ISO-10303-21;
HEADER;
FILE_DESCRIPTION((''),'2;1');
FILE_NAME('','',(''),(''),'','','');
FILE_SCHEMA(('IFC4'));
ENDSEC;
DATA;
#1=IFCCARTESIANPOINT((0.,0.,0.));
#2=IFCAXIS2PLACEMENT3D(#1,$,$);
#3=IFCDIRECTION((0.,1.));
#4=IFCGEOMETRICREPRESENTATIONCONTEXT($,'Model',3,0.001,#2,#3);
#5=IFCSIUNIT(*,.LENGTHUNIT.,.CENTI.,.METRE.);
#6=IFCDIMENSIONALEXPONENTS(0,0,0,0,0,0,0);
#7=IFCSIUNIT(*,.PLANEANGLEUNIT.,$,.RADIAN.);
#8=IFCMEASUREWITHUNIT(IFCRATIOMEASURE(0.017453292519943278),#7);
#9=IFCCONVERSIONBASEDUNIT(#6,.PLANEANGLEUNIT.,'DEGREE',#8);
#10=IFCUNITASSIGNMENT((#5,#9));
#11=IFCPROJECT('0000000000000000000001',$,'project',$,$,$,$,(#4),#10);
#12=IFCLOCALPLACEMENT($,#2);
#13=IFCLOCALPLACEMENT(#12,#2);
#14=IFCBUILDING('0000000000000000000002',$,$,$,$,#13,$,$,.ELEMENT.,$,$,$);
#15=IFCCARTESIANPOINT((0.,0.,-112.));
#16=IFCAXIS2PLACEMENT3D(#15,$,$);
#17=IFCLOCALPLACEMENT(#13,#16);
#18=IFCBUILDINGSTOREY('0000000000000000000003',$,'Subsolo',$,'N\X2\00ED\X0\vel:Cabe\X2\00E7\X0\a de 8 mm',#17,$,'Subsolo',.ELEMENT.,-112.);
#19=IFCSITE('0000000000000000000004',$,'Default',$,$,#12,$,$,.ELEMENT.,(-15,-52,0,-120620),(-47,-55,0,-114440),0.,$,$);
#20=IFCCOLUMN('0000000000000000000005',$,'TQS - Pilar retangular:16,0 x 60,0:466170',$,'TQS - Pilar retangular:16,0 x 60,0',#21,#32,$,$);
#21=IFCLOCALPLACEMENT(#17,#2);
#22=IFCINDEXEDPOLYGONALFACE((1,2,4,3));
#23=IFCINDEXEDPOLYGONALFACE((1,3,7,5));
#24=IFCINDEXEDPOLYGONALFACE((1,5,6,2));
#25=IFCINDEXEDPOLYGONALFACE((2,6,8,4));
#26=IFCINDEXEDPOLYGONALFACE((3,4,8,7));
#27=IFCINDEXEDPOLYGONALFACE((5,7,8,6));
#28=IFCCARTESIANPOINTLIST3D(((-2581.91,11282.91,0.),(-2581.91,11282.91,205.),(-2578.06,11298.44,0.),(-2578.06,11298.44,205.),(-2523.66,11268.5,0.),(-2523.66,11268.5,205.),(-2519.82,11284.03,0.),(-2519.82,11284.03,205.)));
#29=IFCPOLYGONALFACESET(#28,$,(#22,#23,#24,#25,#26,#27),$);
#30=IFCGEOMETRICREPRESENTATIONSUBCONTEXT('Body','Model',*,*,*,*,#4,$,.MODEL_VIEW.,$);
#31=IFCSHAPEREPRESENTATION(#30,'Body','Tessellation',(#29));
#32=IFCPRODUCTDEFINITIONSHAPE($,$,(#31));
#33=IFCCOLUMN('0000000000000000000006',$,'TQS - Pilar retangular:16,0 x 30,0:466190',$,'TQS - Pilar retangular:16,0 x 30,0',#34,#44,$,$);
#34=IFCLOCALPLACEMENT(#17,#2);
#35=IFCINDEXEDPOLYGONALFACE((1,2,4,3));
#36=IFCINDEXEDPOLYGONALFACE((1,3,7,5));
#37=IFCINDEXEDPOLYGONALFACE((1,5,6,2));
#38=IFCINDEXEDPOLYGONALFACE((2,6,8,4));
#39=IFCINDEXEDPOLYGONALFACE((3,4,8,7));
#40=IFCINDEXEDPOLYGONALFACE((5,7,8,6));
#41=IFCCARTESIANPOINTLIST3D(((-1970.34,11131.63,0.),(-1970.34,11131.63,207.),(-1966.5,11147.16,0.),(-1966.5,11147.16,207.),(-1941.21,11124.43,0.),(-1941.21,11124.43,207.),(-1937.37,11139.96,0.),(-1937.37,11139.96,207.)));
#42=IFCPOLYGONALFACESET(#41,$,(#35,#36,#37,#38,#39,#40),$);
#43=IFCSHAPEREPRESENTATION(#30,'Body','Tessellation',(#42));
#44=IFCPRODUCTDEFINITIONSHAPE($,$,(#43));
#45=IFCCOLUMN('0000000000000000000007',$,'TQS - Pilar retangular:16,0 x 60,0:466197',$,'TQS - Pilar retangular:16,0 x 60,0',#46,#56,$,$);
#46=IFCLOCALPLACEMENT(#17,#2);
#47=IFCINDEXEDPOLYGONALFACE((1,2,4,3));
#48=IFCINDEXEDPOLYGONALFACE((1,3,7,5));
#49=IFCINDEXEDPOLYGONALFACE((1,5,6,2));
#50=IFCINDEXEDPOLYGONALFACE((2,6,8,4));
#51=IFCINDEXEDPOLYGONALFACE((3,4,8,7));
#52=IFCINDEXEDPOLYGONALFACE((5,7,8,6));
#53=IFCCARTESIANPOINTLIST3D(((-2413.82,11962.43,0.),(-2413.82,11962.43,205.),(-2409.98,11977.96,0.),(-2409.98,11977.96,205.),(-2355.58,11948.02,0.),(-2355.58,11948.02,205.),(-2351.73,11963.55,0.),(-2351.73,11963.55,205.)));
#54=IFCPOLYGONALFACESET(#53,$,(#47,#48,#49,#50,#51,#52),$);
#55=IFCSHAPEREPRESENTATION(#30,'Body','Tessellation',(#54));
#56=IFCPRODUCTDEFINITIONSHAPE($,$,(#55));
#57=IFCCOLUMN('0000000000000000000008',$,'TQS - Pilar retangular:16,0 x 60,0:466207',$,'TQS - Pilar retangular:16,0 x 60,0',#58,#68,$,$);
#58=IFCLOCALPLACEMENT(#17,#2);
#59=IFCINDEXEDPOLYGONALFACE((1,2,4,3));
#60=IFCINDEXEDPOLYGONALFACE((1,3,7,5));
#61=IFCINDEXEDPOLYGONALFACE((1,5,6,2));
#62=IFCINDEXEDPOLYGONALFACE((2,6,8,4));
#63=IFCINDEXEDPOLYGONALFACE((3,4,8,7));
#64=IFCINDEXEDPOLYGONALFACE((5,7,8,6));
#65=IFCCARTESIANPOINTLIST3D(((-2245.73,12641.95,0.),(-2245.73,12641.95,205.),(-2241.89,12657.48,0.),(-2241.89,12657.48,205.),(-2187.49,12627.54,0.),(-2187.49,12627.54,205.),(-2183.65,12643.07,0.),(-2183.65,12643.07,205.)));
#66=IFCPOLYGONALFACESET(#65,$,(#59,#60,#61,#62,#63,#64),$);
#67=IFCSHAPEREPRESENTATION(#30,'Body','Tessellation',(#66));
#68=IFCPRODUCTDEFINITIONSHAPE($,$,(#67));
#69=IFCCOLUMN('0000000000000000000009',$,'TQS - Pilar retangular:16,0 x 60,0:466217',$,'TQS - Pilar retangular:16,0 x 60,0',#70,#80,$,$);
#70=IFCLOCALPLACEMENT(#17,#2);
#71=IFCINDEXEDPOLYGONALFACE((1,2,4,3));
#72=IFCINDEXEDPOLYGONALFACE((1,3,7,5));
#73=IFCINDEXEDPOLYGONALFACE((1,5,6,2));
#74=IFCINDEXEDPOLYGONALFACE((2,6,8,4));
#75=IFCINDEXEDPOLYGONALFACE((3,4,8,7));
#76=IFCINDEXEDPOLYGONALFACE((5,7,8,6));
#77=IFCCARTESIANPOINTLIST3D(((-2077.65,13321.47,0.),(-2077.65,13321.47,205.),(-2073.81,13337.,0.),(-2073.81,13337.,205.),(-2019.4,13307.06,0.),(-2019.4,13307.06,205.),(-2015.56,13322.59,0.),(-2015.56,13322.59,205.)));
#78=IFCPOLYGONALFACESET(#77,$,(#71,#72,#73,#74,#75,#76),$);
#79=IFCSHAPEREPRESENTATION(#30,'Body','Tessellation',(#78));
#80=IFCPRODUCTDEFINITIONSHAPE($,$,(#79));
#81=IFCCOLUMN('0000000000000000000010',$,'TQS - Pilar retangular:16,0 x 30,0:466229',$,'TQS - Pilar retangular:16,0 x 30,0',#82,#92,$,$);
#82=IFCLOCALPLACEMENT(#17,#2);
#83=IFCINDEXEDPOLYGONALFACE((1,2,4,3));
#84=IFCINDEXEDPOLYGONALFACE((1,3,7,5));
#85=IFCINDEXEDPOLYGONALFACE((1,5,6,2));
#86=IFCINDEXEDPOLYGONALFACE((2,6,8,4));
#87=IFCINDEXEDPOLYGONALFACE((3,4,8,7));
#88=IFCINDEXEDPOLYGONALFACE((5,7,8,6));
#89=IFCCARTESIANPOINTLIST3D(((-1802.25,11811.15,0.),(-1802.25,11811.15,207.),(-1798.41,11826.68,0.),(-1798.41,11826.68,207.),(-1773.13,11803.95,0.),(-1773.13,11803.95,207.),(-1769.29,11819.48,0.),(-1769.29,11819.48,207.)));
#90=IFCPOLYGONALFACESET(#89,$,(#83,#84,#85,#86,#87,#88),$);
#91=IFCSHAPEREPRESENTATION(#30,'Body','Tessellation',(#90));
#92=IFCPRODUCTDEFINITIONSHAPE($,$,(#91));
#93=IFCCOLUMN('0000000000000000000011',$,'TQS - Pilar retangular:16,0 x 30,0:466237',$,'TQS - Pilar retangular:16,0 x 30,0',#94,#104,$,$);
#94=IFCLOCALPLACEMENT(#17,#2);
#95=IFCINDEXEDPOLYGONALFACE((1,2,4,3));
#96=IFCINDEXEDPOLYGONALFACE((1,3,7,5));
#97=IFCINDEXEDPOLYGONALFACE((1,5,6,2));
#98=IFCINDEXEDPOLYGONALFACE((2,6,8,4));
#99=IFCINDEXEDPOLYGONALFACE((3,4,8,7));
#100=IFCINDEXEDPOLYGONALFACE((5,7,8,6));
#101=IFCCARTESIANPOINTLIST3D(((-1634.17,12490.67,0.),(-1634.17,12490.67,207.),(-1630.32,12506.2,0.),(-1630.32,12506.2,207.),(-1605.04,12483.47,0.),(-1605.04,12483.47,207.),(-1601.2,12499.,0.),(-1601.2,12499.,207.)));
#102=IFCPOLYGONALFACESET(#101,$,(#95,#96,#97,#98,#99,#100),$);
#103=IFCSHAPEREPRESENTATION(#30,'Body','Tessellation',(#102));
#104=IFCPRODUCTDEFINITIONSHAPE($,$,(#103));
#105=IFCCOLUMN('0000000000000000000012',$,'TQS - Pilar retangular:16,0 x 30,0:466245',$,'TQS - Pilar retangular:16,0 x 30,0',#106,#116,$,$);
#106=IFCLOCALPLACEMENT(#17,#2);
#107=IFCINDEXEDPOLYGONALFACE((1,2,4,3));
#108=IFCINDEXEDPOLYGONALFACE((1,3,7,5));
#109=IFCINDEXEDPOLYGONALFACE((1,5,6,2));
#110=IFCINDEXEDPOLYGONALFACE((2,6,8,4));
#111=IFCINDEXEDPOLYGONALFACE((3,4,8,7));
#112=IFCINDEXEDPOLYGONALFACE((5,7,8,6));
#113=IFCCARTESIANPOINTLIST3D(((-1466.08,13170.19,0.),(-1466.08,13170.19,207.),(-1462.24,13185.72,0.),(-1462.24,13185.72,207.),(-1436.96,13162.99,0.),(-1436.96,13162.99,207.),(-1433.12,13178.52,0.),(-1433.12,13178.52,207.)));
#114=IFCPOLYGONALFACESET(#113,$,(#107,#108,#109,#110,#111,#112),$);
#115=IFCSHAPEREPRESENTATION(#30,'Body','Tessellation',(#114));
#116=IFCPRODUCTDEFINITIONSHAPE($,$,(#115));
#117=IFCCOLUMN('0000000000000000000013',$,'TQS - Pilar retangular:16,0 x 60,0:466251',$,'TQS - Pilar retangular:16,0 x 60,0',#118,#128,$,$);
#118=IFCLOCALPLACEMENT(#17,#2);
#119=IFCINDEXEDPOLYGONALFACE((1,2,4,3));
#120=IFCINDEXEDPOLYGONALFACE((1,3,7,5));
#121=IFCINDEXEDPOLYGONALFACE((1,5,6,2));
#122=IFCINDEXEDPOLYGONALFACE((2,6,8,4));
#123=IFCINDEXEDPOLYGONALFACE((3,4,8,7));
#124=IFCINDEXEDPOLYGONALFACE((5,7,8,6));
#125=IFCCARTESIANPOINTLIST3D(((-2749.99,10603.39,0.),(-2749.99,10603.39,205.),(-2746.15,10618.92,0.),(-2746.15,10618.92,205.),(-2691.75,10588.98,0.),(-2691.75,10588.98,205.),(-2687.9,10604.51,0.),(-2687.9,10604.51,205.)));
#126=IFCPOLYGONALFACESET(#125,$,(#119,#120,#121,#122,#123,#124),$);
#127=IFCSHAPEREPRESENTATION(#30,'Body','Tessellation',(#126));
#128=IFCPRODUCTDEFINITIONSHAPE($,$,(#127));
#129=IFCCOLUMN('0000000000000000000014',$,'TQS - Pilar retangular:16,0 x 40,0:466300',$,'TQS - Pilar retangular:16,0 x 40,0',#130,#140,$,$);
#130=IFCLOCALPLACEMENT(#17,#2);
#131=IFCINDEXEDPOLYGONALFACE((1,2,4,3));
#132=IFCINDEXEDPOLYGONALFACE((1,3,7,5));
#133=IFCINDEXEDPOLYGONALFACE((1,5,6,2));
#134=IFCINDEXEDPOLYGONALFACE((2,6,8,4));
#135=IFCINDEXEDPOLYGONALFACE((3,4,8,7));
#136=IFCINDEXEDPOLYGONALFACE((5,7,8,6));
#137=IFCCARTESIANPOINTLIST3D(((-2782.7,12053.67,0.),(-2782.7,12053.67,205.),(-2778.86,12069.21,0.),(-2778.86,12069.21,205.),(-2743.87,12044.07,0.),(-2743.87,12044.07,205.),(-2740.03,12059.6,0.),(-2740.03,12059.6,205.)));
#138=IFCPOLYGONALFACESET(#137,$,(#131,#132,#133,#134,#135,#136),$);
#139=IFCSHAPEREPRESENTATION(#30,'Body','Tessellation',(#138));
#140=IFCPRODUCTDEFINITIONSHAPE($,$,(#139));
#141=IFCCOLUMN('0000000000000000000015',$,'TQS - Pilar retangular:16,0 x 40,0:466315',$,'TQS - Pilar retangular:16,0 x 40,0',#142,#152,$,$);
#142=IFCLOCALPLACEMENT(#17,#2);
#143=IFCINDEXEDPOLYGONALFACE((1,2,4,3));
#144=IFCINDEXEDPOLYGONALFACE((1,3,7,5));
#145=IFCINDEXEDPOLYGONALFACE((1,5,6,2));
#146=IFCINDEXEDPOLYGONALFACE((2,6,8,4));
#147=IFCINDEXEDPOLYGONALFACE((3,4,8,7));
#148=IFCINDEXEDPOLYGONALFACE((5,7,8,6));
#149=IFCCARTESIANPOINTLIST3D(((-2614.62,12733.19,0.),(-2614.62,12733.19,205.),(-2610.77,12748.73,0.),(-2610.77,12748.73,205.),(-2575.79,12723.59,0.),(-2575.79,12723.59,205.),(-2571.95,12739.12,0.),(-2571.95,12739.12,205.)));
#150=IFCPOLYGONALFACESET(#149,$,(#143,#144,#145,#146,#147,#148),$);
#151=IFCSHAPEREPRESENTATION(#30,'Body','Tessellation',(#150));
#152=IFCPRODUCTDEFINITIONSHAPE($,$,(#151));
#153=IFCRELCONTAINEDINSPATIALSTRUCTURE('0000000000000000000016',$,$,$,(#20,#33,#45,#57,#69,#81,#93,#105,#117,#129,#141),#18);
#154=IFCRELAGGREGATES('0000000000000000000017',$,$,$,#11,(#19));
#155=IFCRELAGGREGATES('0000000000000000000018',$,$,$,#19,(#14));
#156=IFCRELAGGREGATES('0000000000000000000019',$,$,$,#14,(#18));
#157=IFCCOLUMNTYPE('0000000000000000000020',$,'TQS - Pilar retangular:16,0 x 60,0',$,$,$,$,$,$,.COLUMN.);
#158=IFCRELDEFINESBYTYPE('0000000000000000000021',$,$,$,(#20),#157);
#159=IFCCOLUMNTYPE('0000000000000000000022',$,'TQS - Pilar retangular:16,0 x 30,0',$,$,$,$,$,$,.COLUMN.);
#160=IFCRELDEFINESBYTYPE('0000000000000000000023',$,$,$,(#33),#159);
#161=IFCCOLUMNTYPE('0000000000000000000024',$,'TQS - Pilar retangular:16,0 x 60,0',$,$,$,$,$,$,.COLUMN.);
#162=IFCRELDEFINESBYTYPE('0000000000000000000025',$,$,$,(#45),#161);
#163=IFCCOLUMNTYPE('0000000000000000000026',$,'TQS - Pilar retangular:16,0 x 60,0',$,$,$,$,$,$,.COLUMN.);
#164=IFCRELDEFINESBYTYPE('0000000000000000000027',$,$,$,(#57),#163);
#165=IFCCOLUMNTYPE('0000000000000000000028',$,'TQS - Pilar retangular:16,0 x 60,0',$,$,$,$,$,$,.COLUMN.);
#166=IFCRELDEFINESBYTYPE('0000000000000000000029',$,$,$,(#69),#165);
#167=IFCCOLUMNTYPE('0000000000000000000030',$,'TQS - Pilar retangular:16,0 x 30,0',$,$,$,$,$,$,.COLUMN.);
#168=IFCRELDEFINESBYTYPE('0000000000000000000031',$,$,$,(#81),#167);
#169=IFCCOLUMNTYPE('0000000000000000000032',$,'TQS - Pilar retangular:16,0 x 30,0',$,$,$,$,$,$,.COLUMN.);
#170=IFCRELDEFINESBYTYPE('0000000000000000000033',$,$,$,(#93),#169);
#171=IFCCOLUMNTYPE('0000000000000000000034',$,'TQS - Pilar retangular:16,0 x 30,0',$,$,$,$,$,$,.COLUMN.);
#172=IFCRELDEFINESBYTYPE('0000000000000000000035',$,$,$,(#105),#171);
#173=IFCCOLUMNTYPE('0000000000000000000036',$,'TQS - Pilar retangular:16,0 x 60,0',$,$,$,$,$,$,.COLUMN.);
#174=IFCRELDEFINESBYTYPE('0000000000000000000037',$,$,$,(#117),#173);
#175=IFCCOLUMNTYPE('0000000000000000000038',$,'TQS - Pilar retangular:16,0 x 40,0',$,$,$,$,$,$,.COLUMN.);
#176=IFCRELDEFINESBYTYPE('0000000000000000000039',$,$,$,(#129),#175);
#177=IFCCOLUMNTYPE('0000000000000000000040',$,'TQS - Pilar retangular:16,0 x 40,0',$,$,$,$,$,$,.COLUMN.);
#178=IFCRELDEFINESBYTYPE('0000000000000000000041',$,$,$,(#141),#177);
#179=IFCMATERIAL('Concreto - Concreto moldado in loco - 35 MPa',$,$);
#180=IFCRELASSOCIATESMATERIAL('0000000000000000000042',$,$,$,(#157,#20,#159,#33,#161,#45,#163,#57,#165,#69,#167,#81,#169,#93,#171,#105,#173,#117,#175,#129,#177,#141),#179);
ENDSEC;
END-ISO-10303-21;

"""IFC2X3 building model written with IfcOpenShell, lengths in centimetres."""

from ifc_helpers import new_model, entity, si_unit, converted_unit, direction, frame, frame_2d, origin, origin_2d_with_axis, place, context, subcontext, project, spatial, rectangle, extrude, source, transform, mapped, material, type_object, type_shapes, element, save


model = new_model("IFC2X3")

# Units and contexts
model_context = context("Model", 3, precision=0.001, world=origin(), true_north=direction((0.0, 1.0)))
body_context = subcontext(model_context, "Body", "Model", "MODEL_VIEW")
ifc_project = project(units=[si_unit("LENGTHUNIT", "METRE", prefix="CENTI"), converted_unit("PLANEANGLEUNIT", "DEGREE", entity("IfcRatioMeasure", 0.017453292519943278), si_unit("PLANEANGLEUNIT", "RADIAN"), dimensions=[0, 0, 0, 0, 0, 0, 0])], contexts=[model_context])

# Site, building, storey
site_placement = place(None, origin())
site = spatial("IfcSite", under=ifc_project, at=site_placement, Name="Default", CompositionType="ELEMENT", RefLatitude=(-15, -52, 0, -120620), RefLongitude=(-47, -55, 0, -114440), RefElevation=0.0)
building_placement = place(site_placement, origin())
building = spatial("IfcBuilding", under=site, at=building_placement, CompositionType="ELEMENT")
storey_placement = place(building_placement, frame((0.0, 0.0, -112.0)))
storey = spatial("IfcBuildingStorey", under=building, at=storey_placement, Name="Subsolo", ObjectType="Nível:Cabeça de 8 mm", LongName="Subsolo", CompositionType="ELEMENT", Elevation=-112.0)

# Columns
ifc_material_1 = material(Name="Concreto - Concreto moldado in loco - 35 MPa")
column_type_1 = type_object("IfcColumnType", Name="TQS - Pilar retangular:16,0 x 60,0", PredefinedType="COLUMN", material=ifc_material_1)
shared_shape_1 = source(origin(), body_context, "Body", "SweptSolid", [
    extrude(rectangle(XDim=60.0, YDim=16.0, at=origin_2d_with_axis()), frame((-2550.86, 11283.47, -112.0), z_axis=(0.0, 0.0, 1.0), x_axis=(-0.970743, 0.240122, 0.0)), (0.0, 0.0, 1.0), 205.0),
])
type_shapes(column_type_1, [shared_shape_1])
column_1_placement = place(storey_placement, frame((0.0, 0.0, 112.0)))
element("IfcColumn", 1, at=column_1_placement, inside=storey, type_object=column_type_1, material=ifc_material_1, Name="TQS - Pilar retangular:16,0 x 60,0:466170", ObjectType="TQS - Pilar retangular:16,0 x 60,0", context=body_context, shape_type="MappedRepresentation", body=[
    mapped(shared_shape_1, transform((0.0, 0.0, 0.0), scale=1.0)),
])
column_type_2 = type_object("IfcColumnType", Name="TQS - Pilar retangular:16,0 x 30,0", PredefinedType="COLUMN", material=ifc_material_1)
shared_shape_2 = source(origin(), body_context, "Body", "SweptSolid", [
    extrude(rectangle(XDim=30.0, YDim=16.0, at=frame_2d((0.0, 0.0), x_axis=(1.0, 0.0))), frame((-1953.86, 11135.79, -112.0), z_axis=(0.0, 0.0, 1.0), x_axis=(-0.970743, 0.240122, 0.0)), (0.0, 0.0, 1.0), 207.0),
])
type_shapes(column_type_2, [shared_shape_2])
column_2_placement = place(storey_placement, frame((0.0, 0.0, 112.0)))
element("IfcColumn", 2, at=column_2_placement, inside=storey, type_object=column_type_2, material=ifc_material_1, Name="TQS - Pilar retangular:16,0 x 30,0:466190", ObjectType="TQS - Pilar retangular:16,0 x 30,0", context=body_context, shape_type="MappedRepresentation", body=[
    mapped(shared_shape_2, transform((0.0, 0.0, 0.0), scale=1.0)),
])
column_type_3 = type_object("IfcColumnType", Name="TQS - Pilar retangular:16,0 x 60,0", PredefinedType="COLUMN", material=ifc_material_1)
shared_shape_3 = source(origin(), body_context, "Body", "SweptSolid", [
    extrude(rectangle(XDim=60.0, YDim=16.0, at=origin_2d_with_axis()), frame((-2382.78, 11962.99, -112.0), z_axis=(0.0, 0.0, 1.0), x_axis=(-0.970743, 0.240122, 0.0)), (0.0, 0.0, 1.0), 205.0),
])
type_shapes(column_type_3, [shared_shape_3])
column_3_placement = place(storey_placement, frame((0.0, 0.0, 112.0)))
element("IfcColumn", 3, at=column_3_placement, inside=storey, type_object=column_type_3, material=ifc_material_1, Name="TQS - Pilar retangular:16,0 x 60,0:466197", ObjectType="TQS - Pilar retangular:16,0 x 60,0", context=body_context, shape_type="MappedRepresentation", body=[
    mapped(shared_shape_3, transform((0.0, 0.0, 0.0), scale=1.0)),
])
column_type_4 = type_object("IfcColumnType", Name="TQS - Pilar retangular:16,0 x 60,0", PredefinedType="COLUMN", material=ifc_material_1)
shared_shape_4 = source(origin(), body_context, "Body", "SweptSolid", [
    extrude(rectangle(XDim=60.0, YDim=16.0, at=origin_2d_with_axis()), frame((-2214.69, 12642.51, -112.0), z_axis=(0.0, 0.0, 1.0), x_axis=(-0.970743, 0.240122, 0.0)), (0.0, 0.0, 1.0), 205.0),
])
type_shapes(column_type_4, [shared_shape_4])
column_4_placement = place(storey_placement, frame((0.0, 0.0, 112.0)))
element("IfcColumn", 4, at=column_4_placement, inside=storey, type_object=column_type_4, material=ifc_material_1, Name="TQS - Pilar retangular:16,0 x 60,0:466207", ObjectType="TQS - Pilar retangular:16,0 x 60,0", context=body_context, shape_type="MappedRepresentation", body=[
    mapped(shared_shape_4, transform((0.0, 0.0, 0.0), scale=1.0)),
])
column_type_5 = type_object("IfcColumnType", Name="TQS - Pilar retangular:16,0 x 60,0", PredefinedType="COLUMN", material=ifc_material_1)
shared_shape_5 = source(origin(), body_context, "Body", "SweptSolid", [
    extrude(rectangle(XDim=60.0, YDim=16.0, at=origin_2d_with_axis()), frame((-2046.61, 13322.03, -112.0), z_axis=(0.0, 0.0, 1.0), x_axis=(-0.970743, 0.240122, 0.0)), (0.0, 0.0, 1.0), 205.0),
])
type_shapes(column_type_5, [shared_shape_5])
column_5_placement = place(storey_placement, frame((0.0, 0.0, 112.0)))
element("IfcColumn", 5, at=column_5_placement, inside=storey, type_object=column_type_5, material=ifc_material_1, Name="TQS - Pilar retangular:16,0 x 60,0:466217", ObjectType="TQS - Pilar retangular:16,0 x 60,0", context=body_context, shape_type="MappedRepresentation", body=[
    mapped(shared_shape_5, transform((0.0, 0.0, 0.0), scale=1.0)),
])
column_type_6 = type_object("IfcColumnType", Name="TQS - Pilar retangular:16,0 x 30,0", PredefinedType="COLUMN", material=ifc_material_1)
shared_shape_6 = source(origin(), body_context, "Body", "SweptSolid", [
    extrude(rectangle(XDim=30.0, YDim=16.0, at=origin_2d_with_axis()), frame((-1785.77, 11815.31, -112.0), z_axis=(0.0, 0.0, 1.0), x_axis=(-0.970743, 0.240122, 0.0)), (0.0, 0.0, 1.0), 207.0),
])
type_shapes(column_type_6, [shared_shape_6])
column_6_placement = place(storey_placement, frame((0.0, 0.0, 112.0)))
element("IfcColumn", 6, at=column_6_placement, inside=storey, type_object=column_type_6, material=ifc_material_1, Name="TQS - Pilar retangular:16,0 x 30,0:466229", ObjectType="TQS - Pilar retangular:16,0 x 30,0", context=body_context, shape_type="MappedRepresentation", body=[
    mapped(shared_shape_6, transform((0.0, 0.0, 0.0), scale=1.0)),
])
column_type_7 = type_object("IfcColumnType", Name="TQS - Pilar retangular:16,0 x 30,0", PredefinedType="COLUMN", material=ifc_material_1)
shared_shape_7 = source(origin(), body_context, "Body", "SweptSolid", [
    extrude(rectangle(XDim=30.0, YDim=16.0, at=origin_2d_with_axis()), frame((-1617.68, 12494.83, -112.0), z_axis=(0.0, 0.0, 1.0), x_axis=(-0.970743, 0.240122, 0.0)), (0.0, 0.0, 1.0), 207.0),
])
type_shapes(column_type_7, [shared_shape_7])
column_7_placement = place(storey_placement, frame((0.0, 0.0, 112.0)))
element("IfcColumn", 7, at=column_7_placement, inside=storey, type_object=column_type_7, material=ifc_material_1, Name="TQS - Pilar retangular:16,0 x 30,0:466237", ObjectType="TQS - Pilar retangular:16,0 x 30,0", context=body_context, shape_type="MappedRepresentation", body=[
    mapped(shared_shape_7, transform((0.0, 0.0, 0.0), scale=1.0)),
])
column_type_8 = type_object("IfcColumnType", Name="TQS - Pilar retangular:16,0 x 30,0", PredefinedType="COLUMN", material=ifc_material_1)
shared_shape_8 = source(origin(), body_context, "Body", "SweptSolid", [
    extrude(rectangle(XDim=30.0, YDim=16.0, at=origin_2d_with_axis()), frame((-1449.6, 13174.35, -112.0), z_axis=(0.0, 0.0, 1.0), x_axis=(-0.970743, 0.240122, 0.0)), (0.0, 0.0, 1.0), 207.0),
])
type_shapes(column_type_8, [shared_shape_8])
column_8_placement = place(storey_placement, frame((0.0, 0.0, 112.0)))
element("IfcColumn", 8, at=column_8_placement, inside=storey, type_object=column_type_8, material=ifc_material_1, Name="TQS - Pilar retangular:16,0 x 30,0:466245", ObjectType="TQS - Pilar retangular:16,0 x 30,0", context=body_context, shape_type="MappedRepresentation", body=[
    mapped(shared_shape_8, transform((0.0, 0.0, 0.0), scale=1.0)),
])
column_type_9 = type_object("IfcColumnType", Name="TQS - Pilar retangular:16,0 x 60,0", PredefinedType="COLUMN", material=ifc_material_1)
shared_shape_9 = source(origin(), body_context, "Body", "SweptSolid", [
    extrude(rectangle(XDim=60.0, YDim=16.0, at=origin_2d_with_axis()), frame((-2718.95, 10603.95, -112.0), z_axis=(0.0, 0.0, 1.0), x_axis=(-0.970743, 0.240122, 0.0)), (0.0, 0.0, 1.0), 205.0),
])
type_shapes(column_type_9, [shared_shape_9])
column_9_placement = place(storey_placement, frame((0.0, 0.0, 112.0)))
element("IfcColumn", 9, at=column_9_placement, inside=storey, type_object=column_type_9, material=ifc_material_1, Name="TQS - Pilar retangular:16,0 x 60,0:466251", ObjectType="TQS - Pilar retangular:16,0 x 60,0", context=body_context, shape_type="MappedRepresentation", body=[
    mapped(shared_shape_9, transform((0.0, 0.0, 0.0), scale=1.0)),
])
column_type_10 = type_object("IfcColumnType", Name="TQS - Pilar retangular:16,0 x 40,0", PredefinedType="COLUMN", material=ifc_material_1)
shared_shape_10 = source(origin(), body_context, "Body", "SweptSolid", [
    extrude(rectangle(XDim=40.0, YDim=16.0, at=origin_2d_with_axis()), frame((-2761.37, 12056.64, -112.0), z_axis=(0.0, 0.0, 1.0), x_axis=(-0.970743, 0.240122, 0.0)), (0.0, 0.0, 1.0), 205.0),
])
type_shapes(column_type_10, [shared_shape_10])
column_10_placement = place(storey_placement, frame((0.0, 0.0, 112.0)))
element("IfcColumn", 10, at=column_10_placement, inside=storey, type_object=column_type_10, material=ifc_material_1, Name="TQS - Pilar retangular:16,0 x 40,0:466300", ObjectType="TQS - Pilar retangular:16,0 x 40,0", context=body_context, shape_type="MappedRepresentation", body=[
    mapped(shared_shape_10, transform((0.0, 0.0, 0.0), scale=1.0)),
])
column_type_11 = type_object("IfcColumnType", Name="TQS - Pilar retangular:16,0 x 40,0", PredefinedType="COLUMN", material=ifc_material_1)
shared_shape_11 = source(origin(), body_context, "Body", "SweptSolid", [
    extrude(rectangle(XDim=40.0, YDim=16.0, at=origin_2d_with_axis()), frame((-2593.28, 12736.16, -112.0), z_axis=(0.0, 0.0, 1.0), x_axis=(-0.970743, 0.240122, 0.0)), (0.0, 0.0, 1.0), 205.0),
])
type_shapes(column_type_11, [shared_shape_11])
column_11_placement = place(storey_placement, frame((0.0, 0.0, 112.0)))
element("IfcColumn", 11, at=column_11_placement, inside=storey, type_object=column_type_11, material=ifc_material_1, Name="TQS - Pilar retangular:16,0 x 40,0:466315", ObjectType="TQS - Pilar retangular:16,0 x 40,0", context=body_context, shape_type="MappedRepresentation", body=[
    mapped(shared_shape_11, transform((0.0, 0.0, 0.0), scale=1.0)),
])

save(model, "model.ifc")
